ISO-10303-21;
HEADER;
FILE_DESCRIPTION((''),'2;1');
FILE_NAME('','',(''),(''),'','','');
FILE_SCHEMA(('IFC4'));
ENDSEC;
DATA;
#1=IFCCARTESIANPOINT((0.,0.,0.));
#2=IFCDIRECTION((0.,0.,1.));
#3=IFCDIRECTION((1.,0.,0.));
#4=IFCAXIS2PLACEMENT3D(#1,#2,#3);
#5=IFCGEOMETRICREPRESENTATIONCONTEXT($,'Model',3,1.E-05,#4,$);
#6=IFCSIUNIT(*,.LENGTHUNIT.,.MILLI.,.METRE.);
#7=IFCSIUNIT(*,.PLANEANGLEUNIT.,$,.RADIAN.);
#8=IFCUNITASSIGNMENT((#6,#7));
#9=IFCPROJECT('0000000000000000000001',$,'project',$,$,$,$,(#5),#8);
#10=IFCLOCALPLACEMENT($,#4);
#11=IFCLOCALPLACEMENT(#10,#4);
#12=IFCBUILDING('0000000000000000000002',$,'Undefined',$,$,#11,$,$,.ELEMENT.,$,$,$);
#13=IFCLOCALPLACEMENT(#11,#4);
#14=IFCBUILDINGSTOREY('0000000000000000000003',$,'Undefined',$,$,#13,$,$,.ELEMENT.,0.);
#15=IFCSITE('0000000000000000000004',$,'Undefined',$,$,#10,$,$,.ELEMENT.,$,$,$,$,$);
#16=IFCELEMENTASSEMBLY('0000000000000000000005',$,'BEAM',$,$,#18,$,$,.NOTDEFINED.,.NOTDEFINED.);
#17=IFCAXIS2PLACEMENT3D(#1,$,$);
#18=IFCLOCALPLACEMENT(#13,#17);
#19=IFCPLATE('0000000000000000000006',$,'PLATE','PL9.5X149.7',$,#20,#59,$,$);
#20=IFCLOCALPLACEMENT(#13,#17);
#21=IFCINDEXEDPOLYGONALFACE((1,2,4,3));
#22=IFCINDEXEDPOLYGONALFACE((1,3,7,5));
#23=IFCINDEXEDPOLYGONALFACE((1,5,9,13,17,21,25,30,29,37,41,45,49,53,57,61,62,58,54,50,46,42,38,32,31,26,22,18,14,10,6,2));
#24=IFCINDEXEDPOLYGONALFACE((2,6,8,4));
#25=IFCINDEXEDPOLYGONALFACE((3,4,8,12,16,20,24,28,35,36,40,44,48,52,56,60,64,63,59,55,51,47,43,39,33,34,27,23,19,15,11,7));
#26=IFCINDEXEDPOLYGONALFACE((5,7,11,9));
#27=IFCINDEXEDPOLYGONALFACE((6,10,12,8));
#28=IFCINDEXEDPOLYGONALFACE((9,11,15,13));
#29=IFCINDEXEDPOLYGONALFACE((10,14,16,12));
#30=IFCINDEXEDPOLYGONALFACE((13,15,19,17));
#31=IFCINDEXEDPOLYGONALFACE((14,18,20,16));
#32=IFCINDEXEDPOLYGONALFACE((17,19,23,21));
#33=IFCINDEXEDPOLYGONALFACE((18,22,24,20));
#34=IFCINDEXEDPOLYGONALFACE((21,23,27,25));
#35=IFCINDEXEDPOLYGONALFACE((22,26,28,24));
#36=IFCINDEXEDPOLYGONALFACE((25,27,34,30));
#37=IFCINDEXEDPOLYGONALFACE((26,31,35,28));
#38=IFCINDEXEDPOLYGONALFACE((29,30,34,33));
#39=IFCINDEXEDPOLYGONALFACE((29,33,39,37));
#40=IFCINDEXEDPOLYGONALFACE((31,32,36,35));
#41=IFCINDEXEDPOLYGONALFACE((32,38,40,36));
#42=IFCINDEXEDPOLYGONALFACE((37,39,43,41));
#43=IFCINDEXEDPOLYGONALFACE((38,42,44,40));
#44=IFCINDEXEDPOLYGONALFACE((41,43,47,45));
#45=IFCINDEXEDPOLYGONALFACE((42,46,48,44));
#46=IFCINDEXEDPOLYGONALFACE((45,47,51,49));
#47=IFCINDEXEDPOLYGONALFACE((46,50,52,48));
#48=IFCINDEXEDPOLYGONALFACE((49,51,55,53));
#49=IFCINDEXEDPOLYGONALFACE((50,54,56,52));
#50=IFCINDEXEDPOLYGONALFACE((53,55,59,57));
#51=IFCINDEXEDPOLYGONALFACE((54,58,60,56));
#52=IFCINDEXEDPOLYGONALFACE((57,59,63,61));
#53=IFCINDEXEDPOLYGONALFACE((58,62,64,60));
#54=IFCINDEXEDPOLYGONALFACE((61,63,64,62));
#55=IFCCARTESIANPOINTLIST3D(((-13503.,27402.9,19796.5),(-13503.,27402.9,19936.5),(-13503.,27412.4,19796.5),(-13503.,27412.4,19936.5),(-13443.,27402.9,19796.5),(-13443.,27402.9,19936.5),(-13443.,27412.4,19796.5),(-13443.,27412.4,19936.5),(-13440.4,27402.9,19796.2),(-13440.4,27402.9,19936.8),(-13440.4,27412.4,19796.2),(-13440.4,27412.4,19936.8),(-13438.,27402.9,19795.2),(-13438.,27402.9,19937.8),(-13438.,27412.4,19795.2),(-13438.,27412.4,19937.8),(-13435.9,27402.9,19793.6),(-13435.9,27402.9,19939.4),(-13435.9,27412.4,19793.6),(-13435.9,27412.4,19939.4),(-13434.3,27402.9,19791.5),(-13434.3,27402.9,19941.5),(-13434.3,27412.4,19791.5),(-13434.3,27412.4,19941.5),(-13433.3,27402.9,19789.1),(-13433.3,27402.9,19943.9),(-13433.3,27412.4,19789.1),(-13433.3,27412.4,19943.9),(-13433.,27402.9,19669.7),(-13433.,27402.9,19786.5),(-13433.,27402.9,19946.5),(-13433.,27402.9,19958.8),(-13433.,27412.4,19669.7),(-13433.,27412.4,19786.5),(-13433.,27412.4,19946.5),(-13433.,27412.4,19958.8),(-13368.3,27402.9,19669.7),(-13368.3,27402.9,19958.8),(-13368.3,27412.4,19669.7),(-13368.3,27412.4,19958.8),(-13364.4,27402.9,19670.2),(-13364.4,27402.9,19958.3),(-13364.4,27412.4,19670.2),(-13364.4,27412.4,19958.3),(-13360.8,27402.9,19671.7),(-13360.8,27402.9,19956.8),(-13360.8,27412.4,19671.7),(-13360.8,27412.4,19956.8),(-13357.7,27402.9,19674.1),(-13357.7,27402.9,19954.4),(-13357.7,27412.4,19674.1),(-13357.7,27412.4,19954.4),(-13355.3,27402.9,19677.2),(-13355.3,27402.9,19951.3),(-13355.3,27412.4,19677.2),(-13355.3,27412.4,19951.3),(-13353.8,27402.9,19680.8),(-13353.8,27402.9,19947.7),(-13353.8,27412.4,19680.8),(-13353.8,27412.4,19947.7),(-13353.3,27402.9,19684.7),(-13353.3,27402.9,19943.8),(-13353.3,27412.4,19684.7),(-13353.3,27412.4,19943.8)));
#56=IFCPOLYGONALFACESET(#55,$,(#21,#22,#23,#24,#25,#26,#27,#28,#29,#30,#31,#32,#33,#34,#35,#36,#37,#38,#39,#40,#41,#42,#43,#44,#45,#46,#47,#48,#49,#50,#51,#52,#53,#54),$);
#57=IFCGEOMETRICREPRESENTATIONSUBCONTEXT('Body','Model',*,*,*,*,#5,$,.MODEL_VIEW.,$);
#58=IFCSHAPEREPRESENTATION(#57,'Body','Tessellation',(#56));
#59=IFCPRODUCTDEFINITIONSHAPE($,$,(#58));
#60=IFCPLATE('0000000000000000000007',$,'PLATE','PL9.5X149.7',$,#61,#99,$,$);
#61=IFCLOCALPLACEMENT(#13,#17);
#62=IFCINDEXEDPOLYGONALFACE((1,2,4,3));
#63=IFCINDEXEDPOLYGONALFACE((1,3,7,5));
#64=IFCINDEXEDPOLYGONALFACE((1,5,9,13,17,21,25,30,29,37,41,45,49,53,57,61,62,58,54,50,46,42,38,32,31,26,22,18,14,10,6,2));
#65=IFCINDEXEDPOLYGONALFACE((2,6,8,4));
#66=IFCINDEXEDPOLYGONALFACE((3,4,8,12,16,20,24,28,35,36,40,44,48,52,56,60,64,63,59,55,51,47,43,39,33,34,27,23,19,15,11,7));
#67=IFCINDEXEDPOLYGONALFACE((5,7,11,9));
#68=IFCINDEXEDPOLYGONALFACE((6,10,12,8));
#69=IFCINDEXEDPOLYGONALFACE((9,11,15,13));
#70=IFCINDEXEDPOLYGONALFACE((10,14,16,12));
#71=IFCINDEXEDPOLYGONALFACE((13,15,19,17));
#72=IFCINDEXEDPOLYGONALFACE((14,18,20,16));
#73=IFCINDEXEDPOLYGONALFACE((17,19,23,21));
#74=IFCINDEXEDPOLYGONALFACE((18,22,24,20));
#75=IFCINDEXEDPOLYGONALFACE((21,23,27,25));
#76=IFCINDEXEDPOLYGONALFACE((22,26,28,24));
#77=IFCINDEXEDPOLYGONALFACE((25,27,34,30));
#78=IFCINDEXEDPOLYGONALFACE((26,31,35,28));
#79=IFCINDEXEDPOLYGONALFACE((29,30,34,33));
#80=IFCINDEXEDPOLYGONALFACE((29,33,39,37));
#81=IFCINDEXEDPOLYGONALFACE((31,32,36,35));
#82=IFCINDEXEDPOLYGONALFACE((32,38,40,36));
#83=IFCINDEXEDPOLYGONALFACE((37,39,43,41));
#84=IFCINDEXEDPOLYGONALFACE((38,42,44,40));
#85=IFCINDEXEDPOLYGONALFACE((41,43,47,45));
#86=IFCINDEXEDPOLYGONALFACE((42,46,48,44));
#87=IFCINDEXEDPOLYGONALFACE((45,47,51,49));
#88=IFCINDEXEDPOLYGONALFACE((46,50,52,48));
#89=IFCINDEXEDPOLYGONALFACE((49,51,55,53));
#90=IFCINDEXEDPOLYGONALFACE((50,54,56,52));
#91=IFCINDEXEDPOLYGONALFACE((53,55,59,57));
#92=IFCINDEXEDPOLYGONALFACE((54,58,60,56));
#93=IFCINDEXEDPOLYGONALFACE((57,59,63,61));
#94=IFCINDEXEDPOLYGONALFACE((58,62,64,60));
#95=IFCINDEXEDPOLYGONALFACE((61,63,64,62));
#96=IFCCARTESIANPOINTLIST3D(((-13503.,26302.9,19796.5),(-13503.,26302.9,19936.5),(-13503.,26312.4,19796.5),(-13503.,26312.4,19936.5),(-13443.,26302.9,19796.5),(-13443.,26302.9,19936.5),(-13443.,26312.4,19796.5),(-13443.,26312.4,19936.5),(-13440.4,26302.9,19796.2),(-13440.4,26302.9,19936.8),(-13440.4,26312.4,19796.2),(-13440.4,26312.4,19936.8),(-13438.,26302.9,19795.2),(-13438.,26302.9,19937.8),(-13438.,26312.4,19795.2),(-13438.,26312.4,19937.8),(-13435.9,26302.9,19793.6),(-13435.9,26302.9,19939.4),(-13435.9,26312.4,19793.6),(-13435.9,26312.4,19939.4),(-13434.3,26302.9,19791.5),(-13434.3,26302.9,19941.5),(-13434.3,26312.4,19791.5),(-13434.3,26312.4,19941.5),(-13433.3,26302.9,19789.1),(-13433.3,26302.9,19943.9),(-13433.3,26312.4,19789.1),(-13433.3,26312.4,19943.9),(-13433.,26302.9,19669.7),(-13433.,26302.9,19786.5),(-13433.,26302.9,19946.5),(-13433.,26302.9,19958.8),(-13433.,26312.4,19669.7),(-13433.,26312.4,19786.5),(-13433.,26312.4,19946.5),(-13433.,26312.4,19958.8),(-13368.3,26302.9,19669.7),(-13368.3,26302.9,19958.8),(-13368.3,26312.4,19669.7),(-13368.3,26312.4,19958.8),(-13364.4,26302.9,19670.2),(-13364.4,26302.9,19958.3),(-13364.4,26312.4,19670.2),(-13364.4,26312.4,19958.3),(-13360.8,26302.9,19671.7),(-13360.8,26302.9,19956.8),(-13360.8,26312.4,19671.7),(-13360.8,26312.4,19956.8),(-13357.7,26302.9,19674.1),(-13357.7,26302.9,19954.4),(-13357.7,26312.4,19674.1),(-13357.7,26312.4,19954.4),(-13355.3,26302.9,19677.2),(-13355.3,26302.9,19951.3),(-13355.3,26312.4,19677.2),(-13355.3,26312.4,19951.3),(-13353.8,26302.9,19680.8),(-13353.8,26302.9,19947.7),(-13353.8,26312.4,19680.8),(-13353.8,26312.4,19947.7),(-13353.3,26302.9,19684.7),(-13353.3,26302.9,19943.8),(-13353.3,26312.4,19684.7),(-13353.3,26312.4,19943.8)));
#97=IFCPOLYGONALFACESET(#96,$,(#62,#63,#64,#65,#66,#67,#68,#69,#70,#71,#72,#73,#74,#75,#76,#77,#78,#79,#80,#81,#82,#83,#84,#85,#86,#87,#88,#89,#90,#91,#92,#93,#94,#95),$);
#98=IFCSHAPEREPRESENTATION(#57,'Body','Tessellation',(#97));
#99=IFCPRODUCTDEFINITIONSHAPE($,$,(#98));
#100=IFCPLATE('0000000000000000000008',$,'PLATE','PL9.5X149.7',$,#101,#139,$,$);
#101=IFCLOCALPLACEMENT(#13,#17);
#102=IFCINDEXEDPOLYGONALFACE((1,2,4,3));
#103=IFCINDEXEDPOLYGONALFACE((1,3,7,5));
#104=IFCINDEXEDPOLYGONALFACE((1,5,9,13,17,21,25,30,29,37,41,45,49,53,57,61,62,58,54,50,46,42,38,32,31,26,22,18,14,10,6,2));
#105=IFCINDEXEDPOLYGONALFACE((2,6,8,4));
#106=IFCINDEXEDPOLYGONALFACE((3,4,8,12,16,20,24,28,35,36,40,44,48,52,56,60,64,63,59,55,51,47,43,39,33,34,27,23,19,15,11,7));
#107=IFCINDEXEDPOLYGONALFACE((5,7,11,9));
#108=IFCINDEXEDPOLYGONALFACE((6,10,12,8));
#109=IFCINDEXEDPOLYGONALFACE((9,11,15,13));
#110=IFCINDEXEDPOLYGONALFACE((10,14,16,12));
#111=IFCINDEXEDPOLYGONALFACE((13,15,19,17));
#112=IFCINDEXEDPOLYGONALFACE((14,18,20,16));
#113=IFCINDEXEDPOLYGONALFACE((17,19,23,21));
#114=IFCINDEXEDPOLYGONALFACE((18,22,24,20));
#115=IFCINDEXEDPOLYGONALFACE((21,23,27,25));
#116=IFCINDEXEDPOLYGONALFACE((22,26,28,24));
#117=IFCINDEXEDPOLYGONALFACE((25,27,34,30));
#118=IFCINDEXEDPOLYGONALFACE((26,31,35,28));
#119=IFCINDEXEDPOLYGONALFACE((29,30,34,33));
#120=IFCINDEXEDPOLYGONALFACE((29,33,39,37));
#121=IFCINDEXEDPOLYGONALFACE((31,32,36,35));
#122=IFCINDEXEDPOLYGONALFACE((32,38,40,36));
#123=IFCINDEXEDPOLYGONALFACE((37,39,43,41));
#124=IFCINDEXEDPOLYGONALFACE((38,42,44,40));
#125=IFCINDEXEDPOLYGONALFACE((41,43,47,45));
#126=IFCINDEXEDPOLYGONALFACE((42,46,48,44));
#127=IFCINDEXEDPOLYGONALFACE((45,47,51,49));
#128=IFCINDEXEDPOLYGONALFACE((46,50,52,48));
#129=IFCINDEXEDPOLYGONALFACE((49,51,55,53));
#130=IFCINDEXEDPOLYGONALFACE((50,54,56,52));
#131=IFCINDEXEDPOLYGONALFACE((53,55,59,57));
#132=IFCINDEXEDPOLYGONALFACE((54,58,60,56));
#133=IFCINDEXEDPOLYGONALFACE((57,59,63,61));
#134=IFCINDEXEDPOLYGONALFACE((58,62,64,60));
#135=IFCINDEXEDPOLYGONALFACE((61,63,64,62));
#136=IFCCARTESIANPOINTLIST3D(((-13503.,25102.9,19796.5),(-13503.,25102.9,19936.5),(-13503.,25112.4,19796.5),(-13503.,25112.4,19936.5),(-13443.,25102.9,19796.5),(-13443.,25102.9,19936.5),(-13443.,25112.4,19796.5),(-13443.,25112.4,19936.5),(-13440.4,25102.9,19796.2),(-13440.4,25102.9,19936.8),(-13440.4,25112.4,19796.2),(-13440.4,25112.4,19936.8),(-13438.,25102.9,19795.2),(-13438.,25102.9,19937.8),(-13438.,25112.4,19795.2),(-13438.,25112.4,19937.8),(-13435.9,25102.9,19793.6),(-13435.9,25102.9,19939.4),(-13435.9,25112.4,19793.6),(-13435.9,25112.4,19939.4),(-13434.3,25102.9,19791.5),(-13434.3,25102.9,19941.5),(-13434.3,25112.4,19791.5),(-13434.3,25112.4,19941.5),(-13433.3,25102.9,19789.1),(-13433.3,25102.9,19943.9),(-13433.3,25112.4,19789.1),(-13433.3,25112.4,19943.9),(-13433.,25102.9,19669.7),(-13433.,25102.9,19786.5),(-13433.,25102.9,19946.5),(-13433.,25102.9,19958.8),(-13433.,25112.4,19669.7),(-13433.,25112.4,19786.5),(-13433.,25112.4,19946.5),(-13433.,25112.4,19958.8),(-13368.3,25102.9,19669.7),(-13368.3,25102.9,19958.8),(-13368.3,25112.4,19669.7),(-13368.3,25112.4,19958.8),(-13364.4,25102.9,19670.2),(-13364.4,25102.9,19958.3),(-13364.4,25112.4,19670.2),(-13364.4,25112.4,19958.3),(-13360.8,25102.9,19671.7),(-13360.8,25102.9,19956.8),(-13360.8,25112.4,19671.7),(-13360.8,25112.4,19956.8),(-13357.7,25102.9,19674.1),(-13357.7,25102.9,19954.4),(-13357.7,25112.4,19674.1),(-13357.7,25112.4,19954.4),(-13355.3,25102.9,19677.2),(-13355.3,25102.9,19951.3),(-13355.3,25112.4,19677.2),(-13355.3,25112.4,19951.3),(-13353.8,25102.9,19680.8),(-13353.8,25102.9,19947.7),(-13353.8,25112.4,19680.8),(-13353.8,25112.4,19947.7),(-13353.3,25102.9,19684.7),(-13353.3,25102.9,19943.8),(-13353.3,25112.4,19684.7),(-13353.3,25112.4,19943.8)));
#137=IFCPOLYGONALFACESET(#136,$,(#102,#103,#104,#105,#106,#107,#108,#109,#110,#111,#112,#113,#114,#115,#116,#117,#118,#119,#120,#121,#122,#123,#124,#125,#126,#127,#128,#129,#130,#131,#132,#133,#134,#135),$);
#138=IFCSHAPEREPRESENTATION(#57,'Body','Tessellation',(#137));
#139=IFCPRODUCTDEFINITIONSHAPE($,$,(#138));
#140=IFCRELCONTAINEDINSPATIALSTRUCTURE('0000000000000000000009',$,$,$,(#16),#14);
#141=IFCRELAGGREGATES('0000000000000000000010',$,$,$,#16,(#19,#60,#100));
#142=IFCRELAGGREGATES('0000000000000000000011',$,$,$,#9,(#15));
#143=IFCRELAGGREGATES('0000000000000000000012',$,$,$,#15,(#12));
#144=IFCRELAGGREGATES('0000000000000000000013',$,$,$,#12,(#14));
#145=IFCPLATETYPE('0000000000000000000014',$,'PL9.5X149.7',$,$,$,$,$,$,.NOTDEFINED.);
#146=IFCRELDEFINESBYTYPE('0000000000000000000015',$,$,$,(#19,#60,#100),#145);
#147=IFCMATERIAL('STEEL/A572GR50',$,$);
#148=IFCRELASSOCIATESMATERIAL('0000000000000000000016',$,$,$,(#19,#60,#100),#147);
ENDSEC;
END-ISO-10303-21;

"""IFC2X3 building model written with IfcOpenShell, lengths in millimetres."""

from ifc_helpers import new_model, si_unit, frame, frame_2d, origin_with_axes, place, context, subcontext, project, spatial, polyline, circle_curve, parameter, trimmed, segment, composite_curve, outline, extrude, material, type_object, element, aggregate, save


model = new_model("IFC2X3")

# Units and contexts
model_context = context("Model", 3, precision=1e-05, world=origin_with_axes())
body_context = subcontext(model_context, "Body", "Model", "MODEL_VIEW")
ifc_project = project(units=[si_unit("LENGTHUNIT", "METRE", prefix="MILLI"), si_unit("PLANEANGLEUNIT", "RADIAN")], contexts=[model_context])

# Site, building, storey
site_placement = place(None, origin_with_axes())
site = spatial("IfcSite", under=ifc_project, at=site_placement, Name="Undefined", CompositionType="ELEMENT")
building_placement = place(site_placement, origin_with_axes())
building = spatial("IfcBuilding", under=site, at=building_placement, Name="Undefined", CompositionType="ELEMENT")
storey_placement = place(building_placement, origin_with_axes())
storey = spatial("IfcBuildingStorey", under=building, at=storey_placement, Name="Undefined", CompositionType="ELEMENT", Elevation=0.0)

# Shared definitions
ifc_material_1 = material(Name="STEEL/A572GR50")

# Element assembly
assembly_1_placement = place(storey_placement, origin_with_axes())
assembly_1 = element("IfcElementAssembly", 1, at=assembly_1_placement, inside=storey, Name="BEAM", AssemblyPlace="NOTDEFINED", PredefinedType="NOTDEFINED")

# Plates
plate_type_1 = type_object("IfcPlateType", Name="PL9.5X149.7", PredefinedType="NOTDEFINED")
plate_1_placement = place(assembly_1_placement, frame((-13353.3, 27407.7, 19958.8), z_axis=(0.0, 1.0, 0.0), x_axis=(0.0, 0.0, -1.0)))
plate_1 = element("IfcPlate", 2, at=plate_1_placement, type_object=plate_type_1, material=ifc_material_1, Name="PLATE", Description="PL9.5X149.7", context=body_context, shape_type="SweptSolid", body=[
    extrude(outline(composite_curve([segment(trimmed(circle_curve(frame_2d((15.0, 15.0), x_axis=(-1.0, 0.0)), 15.0), [parameter(0.0)], [parameter(1.570796)], True, "PARAMETER"), True, "CONTINUOUS"), segment(polyline([(15.0, 0.0), (274.1, 0.0)]), True, "CONTINUOUS"), segment(trimmed(circle_curve(frame_2d((274.1, 15.0), x_axis=(0.0, -1.0)), 15.0), [parameter(0.0)], [parameter(1.570796)], True, "PARAMETER"), True, "CONTINUOUS"), segment(polyline([(289.1, 15.0), (289.1, 79.7), (172.3, 79.7)]), True, "CONTINUOUS"), segment(trimmed(circle_curve(frame_2d((172.3, 89.7), x_axis=(0.0, -1.0)), 10.0), [parameter(0.0)], [parameter(4.712389)], False, "PARAMETER"), True, "CONTINUOUS"), segment(polyline([(162.3, 89.7), (162.3, 149.7), (22.3, 149.7), (22.3, 89.7)]), True, "CONTINUOUS"), segment(trimmed(circle_curve(frame_2d((12.3, 89.7), x_axis=(1.0, 0.0)), 10.0), [parameter(0.0)], [parameter(4.712389)], False, "PARAMETER"), True, "CONTINUOUS"), segment(polyline([(12.3, 79.7), (0.0, 79.7), (0.0, 15.0)]), True, "CONTINUOUS")], self_intersect=True)), frame((0.0, 0.0, -4.8), z_axis=(0.0, 0.0, 1.0), x_axis=(1.0, 0.0, 0.0)), (0.0, 0.0, 1.0), 9.5),
])
plate_2_placement = place(assembly_1_placement, frame((-13353.3, 26307.7, 19958.8), z_axis=(0.0, 1.0, 0.0), x_axis=(0.0, 0.0, -1.0)))
plate_2 = element("IfcPlate", 3, at=plate_2_placement, type_object=plate_type_1, material=ifc_material_1, Name="PLATE", Description="PL9.5X149.7", context=body_context, shape_type="SweptSolid", body=[
    extrude(outline(composite_curve([segment(trimmed(circle_curve(frame_2d((15.0, 15.0), x_axis=(-1.0, 0.0)), 15.0), [parameter(0.0)], [parameter(1.570796)], True, "PARAMETER"), True, "CONTINUOUS"), segment(polyline([(15.0, 0.0), (274.1, 0.0)]), True, "CONTINUOUS"), segment(trimmed(circle_curve(frame_2d((274.1, 15.0), x_axis=(0.0, -1.0)), 15.0), [parameter(0.0)], [parameter(1.570796)], True, "PARAMETER"), True, "CONTINUOUS"), segment(polyline([(289.1, 15.0), (289.1, 79.7), (172.3, 79.7)]), True, "CONTINUOUS"), segment(trimmed(circle_curve(frame_2d((172.3, 89.7), x_axis=(0.0, -1.0)), 10.0), [parameter(0.0)], [parameter(4.712389)], False, "PARAMETER"), True, "CONTINUOUS"), segment(polyline([(162.3, 89.7), (162.3, 149.7), (22.3, 149.7), (22.3, 89.7)]), True, "CONTINUOUS"), segment(trimmed(circle_curve(frame_2d((12.3, 89.7), x_axis=(1.0, 0.0)), 10.0), [parameter(0.0)], [parameter(4.712389)], False, "PARAMETER"), True, "CONTINUOUS"), segment(polyline([(12.3, 79.7), (0.0, 79.7), (0.0, 15.0)]), True, "CONTINUOUS")], self_intersect=True)), frame((0.0, 0.0, -4.8), z_axis=(0.0, 0.0, 1.0), x_axis=(1.0, 0.0, 0.0)), (0.0, 0.0, 1.0), 9.5),
])
plate_3_placement = place(assembly_1_placement, frame((-13353.3, 25107.7, 19958.8), z_axis=(0.0, 1.0, 0.0), x_axis=(0.0, 0.0, -1.0)))
plate_3 = element("IfcPlate", 4, at=plate_3_placement, type_object=plate_type_1, material=ifc_material_1, Name="PLATE", Description="PL9.5X149.7", context=body_context, shape_type="SweptSolid", body=[
    extrude(outline(composite_curve([segment(trimmed(circle_curve(frame_2d((15.0, 15.0), x_axis=(-1.0, 0.0)), 15.0), [parameter(0.0)], [parameter(1.570796)], True, "PARAMETER"), True, "CONTINUOUS"), segment(polyline([(15.0, 0.0), (274.1, 0.0)]), True, "CONTINUOUS"), segment(trimmed(circle_curve(frame_2d((274.1, 15.0), x_axis=(0.0, -1.0)), 15.0), [parameter(0.0)], [parameter(1.570796)], True, "PARAMETER"), True, "CONTINUOUS"), segment(polyline([(289.1, 15.0), (289.1, 79.7), (172.3, 79.7)]), True, "CONTINUOUS"), segment(trimmed(circle_curve(frame_2d((172.3, 89.7), x_axis=(0.0, -1.0)), 10.0), [parameter(0.0)], [parameter(4.712389)], False, "PARAMETER"), True, "CONTINUOUS"), segment(polyline([(162.3, 89.7), (162.3, 149.7), (22.3, 149.7), (22.3, 89.7)]), True, "CONTINUOUS"), segment(trimmed(circle_curve(frame_2d((12.3, 89.7), x_axis=(1.0, 0.0)), 10.0), [parameter(0.0)], [parameter(4.712389)], False, "PARAMETER"), True, "CONTINUOUS"), segment(polyline([(12.3, 79.7), (0.0, 79.7), (0.0, 15.0)]), True, "CONTINUOUS")], self_intersect=True)), frame((0.0, 0.0, -4.8), z_axis=(0.0, 0.0, 1.0), x_axis=(1.0, 0.0, 0.0)), (0.0, 0.0, 1.0), 9.5),
])

aggregate(assembly_1, [plate_1, plate_2, plate_3])

save(model, "model.ifc")
